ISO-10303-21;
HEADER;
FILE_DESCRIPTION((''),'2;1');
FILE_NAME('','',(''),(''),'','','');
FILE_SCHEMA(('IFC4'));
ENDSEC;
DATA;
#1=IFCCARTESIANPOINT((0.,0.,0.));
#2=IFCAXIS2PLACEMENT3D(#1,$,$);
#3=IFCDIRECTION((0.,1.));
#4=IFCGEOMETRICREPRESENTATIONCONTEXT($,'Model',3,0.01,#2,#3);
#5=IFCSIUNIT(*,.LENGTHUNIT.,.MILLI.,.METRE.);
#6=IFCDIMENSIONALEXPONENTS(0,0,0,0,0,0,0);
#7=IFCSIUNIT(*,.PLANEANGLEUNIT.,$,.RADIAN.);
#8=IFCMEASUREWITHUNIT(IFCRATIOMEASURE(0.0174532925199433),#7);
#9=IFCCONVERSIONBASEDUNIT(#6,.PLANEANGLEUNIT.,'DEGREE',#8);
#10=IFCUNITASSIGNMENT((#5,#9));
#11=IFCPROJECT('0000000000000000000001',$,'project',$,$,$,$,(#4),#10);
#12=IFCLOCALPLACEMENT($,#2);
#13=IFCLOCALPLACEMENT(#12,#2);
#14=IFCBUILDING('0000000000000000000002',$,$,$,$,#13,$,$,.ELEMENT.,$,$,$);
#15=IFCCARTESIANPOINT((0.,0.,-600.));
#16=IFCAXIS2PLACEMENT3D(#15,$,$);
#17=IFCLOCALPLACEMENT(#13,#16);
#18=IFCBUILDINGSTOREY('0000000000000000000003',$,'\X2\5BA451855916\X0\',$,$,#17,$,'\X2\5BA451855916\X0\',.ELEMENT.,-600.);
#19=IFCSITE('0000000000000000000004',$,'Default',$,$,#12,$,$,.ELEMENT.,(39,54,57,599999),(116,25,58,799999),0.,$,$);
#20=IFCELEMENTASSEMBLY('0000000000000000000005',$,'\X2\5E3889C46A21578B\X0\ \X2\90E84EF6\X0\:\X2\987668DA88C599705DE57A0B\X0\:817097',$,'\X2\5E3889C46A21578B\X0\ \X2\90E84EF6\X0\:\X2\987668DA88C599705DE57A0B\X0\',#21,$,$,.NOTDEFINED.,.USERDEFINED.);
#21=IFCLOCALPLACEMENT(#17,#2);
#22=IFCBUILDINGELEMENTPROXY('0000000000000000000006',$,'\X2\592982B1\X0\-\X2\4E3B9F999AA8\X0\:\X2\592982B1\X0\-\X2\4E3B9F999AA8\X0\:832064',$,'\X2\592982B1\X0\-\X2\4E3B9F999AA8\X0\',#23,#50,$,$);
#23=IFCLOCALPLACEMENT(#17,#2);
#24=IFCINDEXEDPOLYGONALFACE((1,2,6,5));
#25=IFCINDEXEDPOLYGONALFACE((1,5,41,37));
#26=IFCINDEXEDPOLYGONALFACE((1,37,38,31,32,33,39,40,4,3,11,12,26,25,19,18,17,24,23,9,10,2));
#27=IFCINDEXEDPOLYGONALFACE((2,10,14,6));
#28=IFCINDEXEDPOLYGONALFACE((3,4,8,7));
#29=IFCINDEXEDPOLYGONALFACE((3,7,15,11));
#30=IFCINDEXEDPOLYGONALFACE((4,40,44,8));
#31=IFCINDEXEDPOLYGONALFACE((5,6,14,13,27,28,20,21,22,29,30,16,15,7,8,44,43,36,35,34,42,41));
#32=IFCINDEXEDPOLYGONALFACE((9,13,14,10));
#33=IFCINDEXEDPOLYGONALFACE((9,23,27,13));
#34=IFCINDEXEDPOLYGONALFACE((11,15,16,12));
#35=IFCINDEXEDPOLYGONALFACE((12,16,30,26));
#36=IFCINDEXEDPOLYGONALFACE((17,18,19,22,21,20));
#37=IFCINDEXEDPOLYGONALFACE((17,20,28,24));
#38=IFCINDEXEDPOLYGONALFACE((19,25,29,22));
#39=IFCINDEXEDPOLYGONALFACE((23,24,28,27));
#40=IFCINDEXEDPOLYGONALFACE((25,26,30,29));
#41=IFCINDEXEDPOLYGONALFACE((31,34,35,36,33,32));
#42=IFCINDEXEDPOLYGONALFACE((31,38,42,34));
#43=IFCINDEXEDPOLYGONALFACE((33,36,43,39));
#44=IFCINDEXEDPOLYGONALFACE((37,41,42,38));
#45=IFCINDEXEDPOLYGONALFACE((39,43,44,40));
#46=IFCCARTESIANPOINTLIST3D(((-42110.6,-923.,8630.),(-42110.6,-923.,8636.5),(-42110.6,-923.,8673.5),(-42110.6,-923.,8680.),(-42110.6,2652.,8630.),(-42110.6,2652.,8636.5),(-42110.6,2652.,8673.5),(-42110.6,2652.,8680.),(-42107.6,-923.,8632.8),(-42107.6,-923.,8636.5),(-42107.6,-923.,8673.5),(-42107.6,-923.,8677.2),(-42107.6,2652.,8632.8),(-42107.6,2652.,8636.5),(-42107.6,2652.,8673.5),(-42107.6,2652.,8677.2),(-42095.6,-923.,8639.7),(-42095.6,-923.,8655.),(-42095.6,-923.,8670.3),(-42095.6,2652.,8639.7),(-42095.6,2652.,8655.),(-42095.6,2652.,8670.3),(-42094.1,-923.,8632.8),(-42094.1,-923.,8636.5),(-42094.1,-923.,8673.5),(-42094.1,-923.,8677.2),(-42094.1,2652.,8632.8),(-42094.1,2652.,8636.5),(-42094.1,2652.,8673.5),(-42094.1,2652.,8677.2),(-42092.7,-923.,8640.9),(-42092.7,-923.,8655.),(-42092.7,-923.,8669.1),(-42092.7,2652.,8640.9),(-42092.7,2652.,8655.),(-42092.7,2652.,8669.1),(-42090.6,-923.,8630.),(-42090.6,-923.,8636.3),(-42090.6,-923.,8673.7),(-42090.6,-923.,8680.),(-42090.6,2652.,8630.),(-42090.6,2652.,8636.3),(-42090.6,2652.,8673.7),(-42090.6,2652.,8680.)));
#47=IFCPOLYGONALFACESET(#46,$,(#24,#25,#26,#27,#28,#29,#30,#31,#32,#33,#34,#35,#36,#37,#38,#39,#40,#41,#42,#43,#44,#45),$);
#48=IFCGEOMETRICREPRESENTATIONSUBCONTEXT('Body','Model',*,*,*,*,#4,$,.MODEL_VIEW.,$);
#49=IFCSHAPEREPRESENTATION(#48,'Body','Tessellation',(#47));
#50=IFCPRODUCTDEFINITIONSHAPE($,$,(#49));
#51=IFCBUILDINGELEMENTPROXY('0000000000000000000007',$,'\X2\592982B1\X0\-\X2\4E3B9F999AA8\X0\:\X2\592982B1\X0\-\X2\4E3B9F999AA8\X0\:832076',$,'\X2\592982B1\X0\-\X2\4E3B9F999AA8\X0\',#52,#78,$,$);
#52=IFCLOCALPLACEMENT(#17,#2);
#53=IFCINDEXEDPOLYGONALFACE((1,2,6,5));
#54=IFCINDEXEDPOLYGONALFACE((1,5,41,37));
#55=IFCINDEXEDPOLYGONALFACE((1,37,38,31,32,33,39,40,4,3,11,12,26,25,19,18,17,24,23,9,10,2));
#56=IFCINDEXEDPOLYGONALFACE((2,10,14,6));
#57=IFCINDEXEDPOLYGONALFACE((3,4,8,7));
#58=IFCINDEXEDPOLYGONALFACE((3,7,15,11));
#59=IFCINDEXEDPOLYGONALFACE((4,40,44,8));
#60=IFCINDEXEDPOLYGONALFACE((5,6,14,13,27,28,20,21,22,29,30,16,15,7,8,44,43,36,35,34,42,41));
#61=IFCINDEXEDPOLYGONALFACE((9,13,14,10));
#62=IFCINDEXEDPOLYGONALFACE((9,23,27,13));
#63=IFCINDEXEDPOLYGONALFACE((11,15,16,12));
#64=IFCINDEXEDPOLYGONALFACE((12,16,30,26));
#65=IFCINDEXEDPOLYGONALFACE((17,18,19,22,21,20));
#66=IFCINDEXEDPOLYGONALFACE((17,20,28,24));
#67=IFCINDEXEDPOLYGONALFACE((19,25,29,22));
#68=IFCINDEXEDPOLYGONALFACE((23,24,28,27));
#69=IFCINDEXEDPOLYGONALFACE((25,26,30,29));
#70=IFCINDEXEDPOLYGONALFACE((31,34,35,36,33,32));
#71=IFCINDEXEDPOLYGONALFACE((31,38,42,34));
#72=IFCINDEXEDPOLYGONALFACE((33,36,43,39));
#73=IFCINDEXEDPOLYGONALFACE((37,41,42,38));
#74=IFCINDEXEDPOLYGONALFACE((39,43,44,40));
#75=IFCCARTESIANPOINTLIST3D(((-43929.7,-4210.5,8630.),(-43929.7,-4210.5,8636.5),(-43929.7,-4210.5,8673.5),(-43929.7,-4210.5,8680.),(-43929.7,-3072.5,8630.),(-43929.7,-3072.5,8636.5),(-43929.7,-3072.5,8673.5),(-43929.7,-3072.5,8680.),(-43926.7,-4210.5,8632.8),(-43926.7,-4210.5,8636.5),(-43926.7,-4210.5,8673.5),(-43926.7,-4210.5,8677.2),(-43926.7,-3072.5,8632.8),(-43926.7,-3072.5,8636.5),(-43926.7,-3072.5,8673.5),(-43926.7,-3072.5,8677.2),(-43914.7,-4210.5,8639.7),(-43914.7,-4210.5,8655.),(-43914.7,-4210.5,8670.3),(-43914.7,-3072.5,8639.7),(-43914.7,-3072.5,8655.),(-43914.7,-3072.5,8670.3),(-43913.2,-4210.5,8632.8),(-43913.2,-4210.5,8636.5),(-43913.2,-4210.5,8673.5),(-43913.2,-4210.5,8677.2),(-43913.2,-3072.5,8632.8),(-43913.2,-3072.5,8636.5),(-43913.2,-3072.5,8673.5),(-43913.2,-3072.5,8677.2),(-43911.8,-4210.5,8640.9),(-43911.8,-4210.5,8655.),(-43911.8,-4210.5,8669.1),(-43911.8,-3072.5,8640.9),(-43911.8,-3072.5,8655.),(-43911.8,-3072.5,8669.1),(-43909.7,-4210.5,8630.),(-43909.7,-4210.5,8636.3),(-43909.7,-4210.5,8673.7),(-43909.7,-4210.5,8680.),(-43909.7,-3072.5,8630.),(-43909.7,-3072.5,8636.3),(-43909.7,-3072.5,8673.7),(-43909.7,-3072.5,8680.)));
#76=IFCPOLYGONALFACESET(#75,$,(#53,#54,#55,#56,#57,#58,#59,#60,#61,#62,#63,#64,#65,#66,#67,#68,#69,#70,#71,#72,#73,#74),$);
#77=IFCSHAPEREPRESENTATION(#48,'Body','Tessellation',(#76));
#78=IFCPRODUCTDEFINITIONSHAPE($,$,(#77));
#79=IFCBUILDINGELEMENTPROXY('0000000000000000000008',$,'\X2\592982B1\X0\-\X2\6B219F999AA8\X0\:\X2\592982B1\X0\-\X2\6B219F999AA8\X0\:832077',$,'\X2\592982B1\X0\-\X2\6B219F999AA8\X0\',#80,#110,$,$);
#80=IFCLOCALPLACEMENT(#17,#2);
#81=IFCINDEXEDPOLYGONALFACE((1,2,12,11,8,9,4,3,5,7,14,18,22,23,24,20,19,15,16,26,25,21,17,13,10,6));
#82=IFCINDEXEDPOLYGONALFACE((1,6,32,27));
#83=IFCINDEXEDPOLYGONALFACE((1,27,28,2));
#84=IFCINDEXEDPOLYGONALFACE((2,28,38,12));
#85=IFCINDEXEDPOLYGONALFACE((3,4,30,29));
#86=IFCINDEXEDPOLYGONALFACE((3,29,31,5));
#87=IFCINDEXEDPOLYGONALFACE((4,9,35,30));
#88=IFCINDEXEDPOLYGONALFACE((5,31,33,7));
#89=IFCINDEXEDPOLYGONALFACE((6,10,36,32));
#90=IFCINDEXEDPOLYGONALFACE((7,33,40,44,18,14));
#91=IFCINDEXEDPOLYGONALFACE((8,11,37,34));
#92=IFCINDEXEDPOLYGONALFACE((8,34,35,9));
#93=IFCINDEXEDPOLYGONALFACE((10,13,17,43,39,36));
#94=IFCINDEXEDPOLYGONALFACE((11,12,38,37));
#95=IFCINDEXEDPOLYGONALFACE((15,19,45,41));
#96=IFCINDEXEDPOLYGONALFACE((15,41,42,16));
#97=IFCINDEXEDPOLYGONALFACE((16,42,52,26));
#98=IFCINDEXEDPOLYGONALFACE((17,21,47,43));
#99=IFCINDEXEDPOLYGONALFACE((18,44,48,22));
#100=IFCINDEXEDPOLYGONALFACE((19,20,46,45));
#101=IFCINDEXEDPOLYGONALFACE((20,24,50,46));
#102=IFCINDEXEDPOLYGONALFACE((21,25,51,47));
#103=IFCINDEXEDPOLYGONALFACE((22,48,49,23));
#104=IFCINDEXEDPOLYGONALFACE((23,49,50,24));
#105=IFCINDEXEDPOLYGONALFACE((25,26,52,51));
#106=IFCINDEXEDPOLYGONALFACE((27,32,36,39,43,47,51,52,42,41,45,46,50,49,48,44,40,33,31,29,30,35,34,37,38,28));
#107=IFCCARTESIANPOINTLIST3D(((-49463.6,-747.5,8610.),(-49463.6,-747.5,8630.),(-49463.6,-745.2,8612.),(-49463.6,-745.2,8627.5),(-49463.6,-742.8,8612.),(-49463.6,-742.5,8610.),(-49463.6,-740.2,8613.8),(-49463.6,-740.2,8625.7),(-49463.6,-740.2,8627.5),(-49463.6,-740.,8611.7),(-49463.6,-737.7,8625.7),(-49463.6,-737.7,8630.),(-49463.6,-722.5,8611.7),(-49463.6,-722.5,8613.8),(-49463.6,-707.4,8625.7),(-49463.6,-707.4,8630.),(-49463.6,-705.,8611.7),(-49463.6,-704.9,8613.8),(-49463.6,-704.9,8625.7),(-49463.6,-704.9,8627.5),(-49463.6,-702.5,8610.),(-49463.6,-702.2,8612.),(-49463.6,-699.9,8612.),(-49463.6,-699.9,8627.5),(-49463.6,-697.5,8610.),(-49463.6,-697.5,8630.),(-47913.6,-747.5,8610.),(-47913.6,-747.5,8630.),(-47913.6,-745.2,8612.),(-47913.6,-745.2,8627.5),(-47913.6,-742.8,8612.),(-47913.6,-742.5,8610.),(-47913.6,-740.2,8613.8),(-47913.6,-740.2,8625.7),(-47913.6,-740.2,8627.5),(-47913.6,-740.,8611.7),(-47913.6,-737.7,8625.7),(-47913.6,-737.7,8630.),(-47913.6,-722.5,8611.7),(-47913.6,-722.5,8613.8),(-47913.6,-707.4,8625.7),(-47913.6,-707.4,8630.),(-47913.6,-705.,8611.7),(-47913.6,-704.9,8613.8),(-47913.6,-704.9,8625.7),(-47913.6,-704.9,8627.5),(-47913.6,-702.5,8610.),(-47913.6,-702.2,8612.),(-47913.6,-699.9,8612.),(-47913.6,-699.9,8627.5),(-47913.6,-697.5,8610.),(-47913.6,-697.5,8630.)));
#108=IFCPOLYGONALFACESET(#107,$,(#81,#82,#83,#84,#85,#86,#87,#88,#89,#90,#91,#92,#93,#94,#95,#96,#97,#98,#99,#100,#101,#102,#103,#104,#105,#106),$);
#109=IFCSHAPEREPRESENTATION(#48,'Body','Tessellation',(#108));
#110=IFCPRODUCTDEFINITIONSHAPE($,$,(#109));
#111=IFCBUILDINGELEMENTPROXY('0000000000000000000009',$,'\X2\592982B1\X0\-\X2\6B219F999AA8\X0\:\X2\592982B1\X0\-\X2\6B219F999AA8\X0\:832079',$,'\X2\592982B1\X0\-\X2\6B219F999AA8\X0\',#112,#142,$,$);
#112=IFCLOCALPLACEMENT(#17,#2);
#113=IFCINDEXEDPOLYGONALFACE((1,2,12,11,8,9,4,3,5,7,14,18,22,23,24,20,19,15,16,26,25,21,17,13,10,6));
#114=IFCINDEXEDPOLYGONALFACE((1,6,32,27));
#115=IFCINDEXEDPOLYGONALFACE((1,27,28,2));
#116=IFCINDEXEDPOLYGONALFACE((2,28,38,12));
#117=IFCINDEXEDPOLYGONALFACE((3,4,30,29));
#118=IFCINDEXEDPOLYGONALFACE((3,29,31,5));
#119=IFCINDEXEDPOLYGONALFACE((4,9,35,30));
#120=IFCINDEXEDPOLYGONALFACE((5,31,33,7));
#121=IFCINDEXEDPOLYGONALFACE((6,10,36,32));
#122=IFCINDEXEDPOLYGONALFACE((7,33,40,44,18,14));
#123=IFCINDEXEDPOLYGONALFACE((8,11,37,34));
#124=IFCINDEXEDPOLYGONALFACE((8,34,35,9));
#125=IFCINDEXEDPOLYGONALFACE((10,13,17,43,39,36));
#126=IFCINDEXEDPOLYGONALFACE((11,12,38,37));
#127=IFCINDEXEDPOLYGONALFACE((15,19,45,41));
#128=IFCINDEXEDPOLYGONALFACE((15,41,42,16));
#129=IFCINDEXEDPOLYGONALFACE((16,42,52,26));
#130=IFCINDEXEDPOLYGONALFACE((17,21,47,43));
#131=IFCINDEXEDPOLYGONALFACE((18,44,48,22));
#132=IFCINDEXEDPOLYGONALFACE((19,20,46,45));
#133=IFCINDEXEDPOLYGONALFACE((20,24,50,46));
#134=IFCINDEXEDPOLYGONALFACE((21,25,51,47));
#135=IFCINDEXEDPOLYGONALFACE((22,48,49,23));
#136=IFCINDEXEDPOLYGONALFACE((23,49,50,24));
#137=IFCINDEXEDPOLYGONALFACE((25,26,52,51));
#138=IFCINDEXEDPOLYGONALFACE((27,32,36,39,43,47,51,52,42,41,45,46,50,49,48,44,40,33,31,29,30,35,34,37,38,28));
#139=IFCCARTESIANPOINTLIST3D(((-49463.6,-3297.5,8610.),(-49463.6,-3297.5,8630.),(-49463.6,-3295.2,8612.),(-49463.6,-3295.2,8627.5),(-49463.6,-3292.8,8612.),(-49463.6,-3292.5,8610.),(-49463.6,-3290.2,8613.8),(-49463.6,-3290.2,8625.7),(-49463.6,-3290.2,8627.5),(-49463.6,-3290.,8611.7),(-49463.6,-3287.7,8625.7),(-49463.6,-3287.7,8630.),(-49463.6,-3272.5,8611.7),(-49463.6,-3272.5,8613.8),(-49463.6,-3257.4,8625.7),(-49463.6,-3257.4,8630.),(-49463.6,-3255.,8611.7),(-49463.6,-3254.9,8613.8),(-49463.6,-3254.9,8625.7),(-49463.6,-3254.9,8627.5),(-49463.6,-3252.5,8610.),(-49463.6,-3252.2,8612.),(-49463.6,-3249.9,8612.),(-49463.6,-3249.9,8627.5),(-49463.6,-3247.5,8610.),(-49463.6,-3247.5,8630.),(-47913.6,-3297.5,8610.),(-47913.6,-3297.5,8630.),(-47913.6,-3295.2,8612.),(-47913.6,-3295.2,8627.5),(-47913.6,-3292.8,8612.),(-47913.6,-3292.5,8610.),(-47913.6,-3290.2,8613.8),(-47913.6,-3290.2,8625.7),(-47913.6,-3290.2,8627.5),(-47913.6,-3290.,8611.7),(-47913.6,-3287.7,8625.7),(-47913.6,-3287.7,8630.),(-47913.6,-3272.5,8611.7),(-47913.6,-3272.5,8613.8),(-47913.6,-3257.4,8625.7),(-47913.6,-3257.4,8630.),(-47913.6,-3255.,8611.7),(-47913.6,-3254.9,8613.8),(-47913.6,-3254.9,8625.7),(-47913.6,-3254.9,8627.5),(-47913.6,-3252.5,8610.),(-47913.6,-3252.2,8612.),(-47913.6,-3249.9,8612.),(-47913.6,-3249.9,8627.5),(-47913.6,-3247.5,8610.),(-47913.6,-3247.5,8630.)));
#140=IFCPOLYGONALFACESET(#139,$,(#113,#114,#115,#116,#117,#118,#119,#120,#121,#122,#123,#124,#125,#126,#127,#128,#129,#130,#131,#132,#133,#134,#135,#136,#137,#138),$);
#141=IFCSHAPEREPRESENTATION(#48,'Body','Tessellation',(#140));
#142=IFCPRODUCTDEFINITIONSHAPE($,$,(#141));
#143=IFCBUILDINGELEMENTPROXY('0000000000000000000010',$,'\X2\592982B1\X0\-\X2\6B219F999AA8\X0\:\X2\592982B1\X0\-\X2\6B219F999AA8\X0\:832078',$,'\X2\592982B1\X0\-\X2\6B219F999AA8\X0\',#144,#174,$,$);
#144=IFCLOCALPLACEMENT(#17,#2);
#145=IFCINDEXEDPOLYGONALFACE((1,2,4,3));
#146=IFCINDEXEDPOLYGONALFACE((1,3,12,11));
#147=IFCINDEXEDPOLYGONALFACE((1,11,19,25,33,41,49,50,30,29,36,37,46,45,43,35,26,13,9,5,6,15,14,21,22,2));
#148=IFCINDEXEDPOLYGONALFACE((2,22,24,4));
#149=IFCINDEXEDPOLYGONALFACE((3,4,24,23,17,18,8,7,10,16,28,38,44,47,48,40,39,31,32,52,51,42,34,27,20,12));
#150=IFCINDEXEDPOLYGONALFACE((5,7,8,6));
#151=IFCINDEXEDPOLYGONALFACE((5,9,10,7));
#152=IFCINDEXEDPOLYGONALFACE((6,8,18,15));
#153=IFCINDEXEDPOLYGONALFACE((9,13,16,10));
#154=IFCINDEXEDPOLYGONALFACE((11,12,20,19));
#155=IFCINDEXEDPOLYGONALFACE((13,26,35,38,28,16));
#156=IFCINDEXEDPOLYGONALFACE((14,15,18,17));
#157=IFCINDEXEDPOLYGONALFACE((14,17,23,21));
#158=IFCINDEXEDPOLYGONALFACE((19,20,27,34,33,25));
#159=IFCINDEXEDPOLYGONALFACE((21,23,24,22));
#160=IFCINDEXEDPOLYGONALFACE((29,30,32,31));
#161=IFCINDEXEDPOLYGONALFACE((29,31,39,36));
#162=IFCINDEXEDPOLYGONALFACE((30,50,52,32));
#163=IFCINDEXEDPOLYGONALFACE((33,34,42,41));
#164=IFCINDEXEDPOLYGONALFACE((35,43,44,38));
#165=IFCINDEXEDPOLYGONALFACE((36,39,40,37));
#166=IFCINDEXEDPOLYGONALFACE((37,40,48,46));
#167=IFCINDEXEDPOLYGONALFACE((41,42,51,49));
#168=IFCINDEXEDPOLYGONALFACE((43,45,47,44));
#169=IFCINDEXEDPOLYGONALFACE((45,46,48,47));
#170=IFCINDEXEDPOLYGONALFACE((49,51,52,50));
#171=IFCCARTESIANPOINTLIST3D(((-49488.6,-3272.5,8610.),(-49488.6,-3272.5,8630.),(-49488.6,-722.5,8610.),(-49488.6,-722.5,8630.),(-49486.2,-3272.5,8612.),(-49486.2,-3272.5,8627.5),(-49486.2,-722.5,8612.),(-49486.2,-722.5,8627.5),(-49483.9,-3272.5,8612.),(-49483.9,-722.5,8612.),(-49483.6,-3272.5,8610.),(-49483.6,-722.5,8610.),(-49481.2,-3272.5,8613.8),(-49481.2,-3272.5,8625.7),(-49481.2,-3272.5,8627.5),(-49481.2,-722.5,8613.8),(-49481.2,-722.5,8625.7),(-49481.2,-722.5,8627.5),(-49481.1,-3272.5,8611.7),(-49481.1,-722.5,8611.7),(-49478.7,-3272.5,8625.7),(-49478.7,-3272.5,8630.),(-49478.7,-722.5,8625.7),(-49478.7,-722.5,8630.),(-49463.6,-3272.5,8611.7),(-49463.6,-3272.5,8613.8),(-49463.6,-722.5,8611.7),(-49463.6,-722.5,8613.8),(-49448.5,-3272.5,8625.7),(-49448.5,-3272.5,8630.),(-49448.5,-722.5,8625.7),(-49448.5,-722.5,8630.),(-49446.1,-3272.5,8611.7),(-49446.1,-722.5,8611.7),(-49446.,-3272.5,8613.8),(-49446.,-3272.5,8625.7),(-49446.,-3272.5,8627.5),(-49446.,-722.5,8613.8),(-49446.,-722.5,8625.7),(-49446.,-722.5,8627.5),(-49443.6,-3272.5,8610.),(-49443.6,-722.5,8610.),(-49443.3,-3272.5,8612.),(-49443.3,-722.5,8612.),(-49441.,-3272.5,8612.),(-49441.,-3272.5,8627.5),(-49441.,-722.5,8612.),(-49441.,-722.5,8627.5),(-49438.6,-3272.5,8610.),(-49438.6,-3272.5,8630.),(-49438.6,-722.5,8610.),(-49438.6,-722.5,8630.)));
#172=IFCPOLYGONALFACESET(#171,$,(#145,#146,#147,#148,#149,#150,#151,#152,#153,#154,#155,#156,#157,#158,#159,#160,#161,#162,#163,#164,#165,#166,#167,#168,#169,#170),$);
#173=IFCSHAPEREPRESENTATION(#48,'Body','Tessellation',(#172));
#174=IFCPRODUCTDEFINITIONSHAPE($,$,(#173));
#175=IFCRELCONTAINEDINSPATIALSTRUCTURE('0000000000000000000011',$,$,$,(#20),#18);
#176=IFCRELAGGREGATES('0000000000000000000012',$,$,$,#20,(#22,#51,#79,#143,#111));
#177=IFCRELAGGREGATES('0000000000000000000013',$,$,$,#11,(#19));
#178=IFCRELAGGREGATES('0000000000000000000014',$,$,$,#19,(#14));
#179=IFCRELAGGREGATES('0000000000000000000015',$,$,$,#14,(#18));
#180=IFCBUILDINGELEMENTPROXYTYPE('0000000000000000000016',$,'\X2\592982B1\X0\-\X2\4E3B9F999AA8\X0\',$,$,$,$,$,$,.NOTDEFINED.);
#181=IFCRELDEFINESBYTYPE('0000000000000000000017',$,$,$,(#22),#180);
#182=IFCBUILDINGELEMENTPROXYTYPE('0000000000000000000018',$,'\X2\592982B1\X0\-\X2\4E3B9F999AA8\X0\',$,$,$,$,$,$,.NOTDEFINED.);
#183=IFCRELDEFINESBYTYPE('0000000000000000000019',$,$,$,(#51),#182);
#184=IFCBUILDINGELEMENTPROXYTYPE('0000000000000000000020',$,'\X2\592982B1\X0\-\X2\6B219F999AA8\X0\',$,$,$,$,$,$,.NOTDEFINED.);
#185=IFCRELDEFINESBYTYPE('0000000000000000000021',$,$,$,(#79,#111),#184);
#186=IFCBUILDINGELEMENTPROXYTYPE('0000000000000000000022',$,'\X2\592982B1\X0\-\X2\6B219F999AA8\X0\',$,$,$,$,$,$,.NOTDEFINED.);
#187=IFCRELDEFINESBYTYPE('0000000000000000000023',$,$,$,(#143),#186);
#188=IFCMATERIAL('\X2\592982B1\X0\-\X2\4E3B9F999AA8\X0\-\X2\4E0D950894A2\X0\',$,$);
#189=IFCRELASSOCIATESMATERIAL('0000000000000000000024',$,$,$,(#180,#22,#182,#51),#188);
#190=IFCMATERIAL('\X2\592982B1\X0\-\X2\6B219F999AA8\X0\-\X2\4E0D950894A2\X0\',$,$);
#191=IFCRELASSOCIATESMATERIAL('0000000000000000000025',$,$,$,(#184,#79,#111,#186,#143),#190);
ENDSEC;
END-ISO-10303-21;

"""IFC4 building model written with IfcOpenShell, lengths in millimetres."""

from ifc_helpers import new_model, entity, si_unit, converted_unit, direction, frame, origin, place, context, subcontext, project, spatial, polyline, outline, extrude, source, transform, mapped, material, type_object, type_shapes, element, aggregate, save


model = new_model("IFC4")

# Units and contexts
model_context = context("Model", 3, precision=0.01, world=origin(), true_north=direction((0.0, 1.0)))
body_context = subcontext(model_context, "Body", "Model", "MODEL_VIEW")
ifc_project = project(units=[si_unit("LENGTHUNIT", "METRE", prefix="MILLI"), converted_unit("PLANEANGLEUNIT", "DEGREE", entity("IfcRatioMeasure", 0.0174532925199433), si_unit("PLANEANGLEUNIT", "RADIAN"), dimensions=[0, 0, 0, 0, 0, 0, 0])], contexts=[model_context])

# Site, building, storey
site_placement = place(None, origin())
site = spatial("IfcSite", under=ifc_project, at=site_placement, Name="Default", CompositionType="ELEMENT", RefLatitude=(39, 54, 57, 599999), RefLongitude=(116, 25, 58, 799999), RefElevation=0.0)
building_placement = place(site_placement, origin())
building = spatial("IfcBuilding", under=site, at=building_placement, CompositionType="ELEMENT")
storey_placement = place(building_placement, frame((0.0, 0.0, -600.0)))
storey = spatial("IfcBuildingStorey", under=building, at=storey_placement, Name="室内外", LongName="室内外", CompositionType="ELEMENT", Elevation=-600.0)

# Element assembly, building element proxies
assembly_1_placement = place(storey_placement, origin())
assembly_1 = element("IfcElementAssembly", 1, at=assembly_1_placement, inside=storey, Name="常规模型 部件:顶棚装饰工程:817097", ObjectType="常规模型 部件:顶棚装饰工程", AssemblyPlace="NOTDEFINED", PredefinedType="USERDEFINED")
ifc_material_1 = material(Name="天花-次龙骨-不锈钢")
ifc_material_2 = material(Name="天花-主龙骨-不锈钢")
building_element_proxy_type_1 = type_object("IfcBuildingElementProxyType", Name="天花-主龙骨", PredefinedType="NOTDEFINED", material=ifc_material_2)
shared_shape_1 = source(origin(), body_context, "Body", "SweptSolid", [
    extrude(outline(polyline([(-25.0, -11.7), (-18.5, -11.7), (-18.5, -8.7), (-22.2, -8.7), (-22.2, 4.8), (-18.5, 4.8), (-15.3, 3.3), (0.0, 3.3), (15.3, 3.3), (18.5, 4.8), (22.2, 4.8), (22.2, -8.7), (18.5, -8.7), (18.5, -11.7), (25.0, -11.7), (25.0, 8.3), (18.7, 8.3), (14.1, 6.2), (0.0, 6.2), (-14.1, 6.2), (-18.7, 8.3), (-25.0, 8.3), (-25.0, -11.7)])), frame((0.0, 1.7, 0.0), z_axis=(1.0, 0.0, 0.0), x_axis=(0.0, 0.0, -1.0)), (0.0, 0.0, 1.0), 3575.0),
])
type_shapes(building_element_proxy_type_1, [shared_shape_1])
proxy_1_placement = place(assembly_1_placement, frame((-42100.6, 2652.0, 8655.0), z_axis=(0.0, 0.0, 1.0), x_axis=(0.0, -1.0, 0.0)))
proxy_1 = element("IfcBuildingElementProxy", 2, at=proxy_1_placement, type_object=building_element_proxy_type_1, material=ifc_material_2, Name="天花-主龙骨:天花-主龙骨:832064", ObjectType="天花-主龙骨", context=body_context, shape_type="MappedRepresentation", body=[
    mapped(shared_shape_1, transform((0.0, 0.0, 0.0), scale=1.0)),
])
building_element_proxy_type_2 = type_object("IfcBuildingElementProxyType", Name="天花-主龙骨", PredefinedType="NOTDEFINED", material=ifc_material_2)
shared_shape_2 = source(origin(), body_context, "Body", "SweptSolid", [
    extrude(outline(polyline([(-25.0, -11.7), (-18.5, -11.7), (-18.5, -8.7), (-22.2, -8.7), (-22.2, 4.8), (-18.5, 4.8), (-15.3, 3.3), (0.0, 3.3), (15.3, 3.3), (18.5, 4.8), (22.2, 4.8), (22.2, -8.7), (18.5, -8.7), (18.5, -11.7), (25.0, -11.7), (25.0, 8.3), (18.7, 8.3), (14.1, 6.2), (0.0, 6.2), (-14.1, 6.2), (-18.7, 8.3), (-25.0, 8.3), (-25.0, -11.7)])), frame((0.0, 1.7, 0.0), z_axis=(1.0, 0.0, 0.0), x_axis=(0.0, 0.0, -1.0)), (0.0, 0.0, 1.0), 1138.0),
])
type_shapes(building_element_proxy_type_2, [shared_shape_2])
proxy_2_placement = place(assembly_1_placement, frame((-43919.7, -3072.5, 8655.0), z_axis=(0.0, 0.0, 1.0), x_axis=(0.0, -1.0, 0.0)))
proxy_2 = element("IfcBuildingElementProxy", 3, at=proxy_2_placement, type_object=building_element_proxy_type_2, material=ifc_material_2, Name="天花-主龙骨:天花-主龙骨:832076", ObjectType="天花-主龙骨", context=body_context, shape_type="MappedRepresentation", body=[
    mapped(shared_shape_2, transform((0.0, 0.0, 0.0), scale=1.0)),
])
building_element_proxy_type_3 = type_object("IfcBuildingElementProxyType", Name="天花-次龙骨", PredefinedType="NOTDEFINED", material=ifc_material_1)
shared_shape_3 = source(origin(), body_context, "Body", "SweptSolid", [
    extrude(outline(polyline([(-25.0, -9.1), (-20.0, -9.1), (-17.5, -7.4), (0.0, -7.4), (17.5, -7.4), (20.0, -9.1), (25.0, -9.1), (25.0, 10.9), (15.1, 10.9), (15.1, 6.6), (17.6, 6.6), (17.6, 8.4), (22.6, 8.4), (22.6, -7.1), (20.3, -7.1), (17.6, -5.3), (0.0, -5.3), (-17.6, -5.3), (-20.3, -7.1), (-22.6, -7.1), (-22.6, 8.4), (-17.6, 8.4), (-17.6, 6.6), (-15.1, 6.6), (-15.1, 10.9), (-25.0, 10.9), (-25.0, -9.1)])), frame((0.0, 0.0, -0.9), z_axis=(1.0, 0.0, 0.0), x_axis=(0.0, 1.0, 0.0)), (0.0, 0.0, 1.0), 1550.0),
])
type_shapes(building_element_proxy_type_3, [shared_shape_3])
proxy_3_placement = place(assembly_1_placement, frame((-49463.6, -722.5, 8620.0)))
proxy_3 = element("IfcBuildingElementProxy", 4, at=proxy_3_placement, type_object=building_element_proxy_type_3, material=ifc_material_1, Name="天花-次龙骨:天花-次龙骨:832077", ObjectType="天花-次龙骨", context=body_context, shape_type="MappedRepresentation", body=[
    mapped(shared_shape_3, transform((0.0, 0.0, 0.0), scale=1.0)),
])
proxy_4_placement = place(assembly_1_placement, frame((-49463.6, -3272.5, 8620.0)))
proxy_4 = element("IfcBuildingElementProxy", 5, at=proxy_4_placement, type_object=building_element_proxy_type_3, material=ifc_material_1, Name="天花-次龙骨:天花-次龙骨:832079", ObjectType="天花-次龙骨", context=body_context, shape_type="MappedRepresentation", body=[
    mapped(shared_shape_3, transform((0.0, 0.0, 0.0), scale=1.0)),
])
building_element_proxy_type_4 = type_object("IfcBuildingElementProxyType", Name="天花-次龙骨", PredefinedType="NOTDEFINED", material=ifc_material_1)
shared_shape_4 = source(origin(), body_context, "Body", "SweptSolid", [
    extrude(outline(polyline([(-25.0, -9.1), (-20.0, -9.1), (-17.5, -7.4), (0.0, -7.4), (17.5, -7.4), (20.0, -9.1), (25.0, -9.1), (25.0, 10.9), (15.1, 10.9), (15.1, 6.6), (17.6, 6.6), (17.6, 8.4), (22.6, 8.4), (22.6, -7.1), (20.3, -7.1), (17.6, -5.3), (0.0, -5.3), (-17.6, -5.3), (-20.3, -7.1), (-22.6, -7.1), (-22.6, 8.4), (-17.6, 8.4), (-17.6, 6.6), (-15.1, 6.6), (-15.1, 10.9), (-25.0, 10.9), (-25.0, -9.1)])), frame((0.0, 0.0, -0.9), z_axis=(1.0, 0.0, 0.0), x_axis=(0.0, 1.0, 0.0)), (0.0, 0.0, 1.0), 2550.0),
])
type_shapes(building_element_proxy_type_4, [shared_shape_4])
proxy_5_placement = place(assembly_1_placement, frame((-49463.6, -722.5, 8620.0), z_axis=(0.0, 0.0, 1.0), x_axis=(0.0, -1.0, 0.0)))
proxy_5 = element("IfcBuildingElementProxy", 6, at=proxy_5_placement, type_object=building_element_proxy_type_4, material=ifc_material_1, Name="天花-次龙骨:天花-次龙骨:832078", ObjectType="天花-次龙骨", context=body_context, shape_type="MappedRepresentation", body=[
    mapped(shared_shape_4, transform((0.0, 0.0, 0.0), scale=1.0)),
])
aggregate(assembly_1, [proxy_1, proxy_2, proxy_3, proxy_5, proxy_4])

save(model, "model.ifc")
